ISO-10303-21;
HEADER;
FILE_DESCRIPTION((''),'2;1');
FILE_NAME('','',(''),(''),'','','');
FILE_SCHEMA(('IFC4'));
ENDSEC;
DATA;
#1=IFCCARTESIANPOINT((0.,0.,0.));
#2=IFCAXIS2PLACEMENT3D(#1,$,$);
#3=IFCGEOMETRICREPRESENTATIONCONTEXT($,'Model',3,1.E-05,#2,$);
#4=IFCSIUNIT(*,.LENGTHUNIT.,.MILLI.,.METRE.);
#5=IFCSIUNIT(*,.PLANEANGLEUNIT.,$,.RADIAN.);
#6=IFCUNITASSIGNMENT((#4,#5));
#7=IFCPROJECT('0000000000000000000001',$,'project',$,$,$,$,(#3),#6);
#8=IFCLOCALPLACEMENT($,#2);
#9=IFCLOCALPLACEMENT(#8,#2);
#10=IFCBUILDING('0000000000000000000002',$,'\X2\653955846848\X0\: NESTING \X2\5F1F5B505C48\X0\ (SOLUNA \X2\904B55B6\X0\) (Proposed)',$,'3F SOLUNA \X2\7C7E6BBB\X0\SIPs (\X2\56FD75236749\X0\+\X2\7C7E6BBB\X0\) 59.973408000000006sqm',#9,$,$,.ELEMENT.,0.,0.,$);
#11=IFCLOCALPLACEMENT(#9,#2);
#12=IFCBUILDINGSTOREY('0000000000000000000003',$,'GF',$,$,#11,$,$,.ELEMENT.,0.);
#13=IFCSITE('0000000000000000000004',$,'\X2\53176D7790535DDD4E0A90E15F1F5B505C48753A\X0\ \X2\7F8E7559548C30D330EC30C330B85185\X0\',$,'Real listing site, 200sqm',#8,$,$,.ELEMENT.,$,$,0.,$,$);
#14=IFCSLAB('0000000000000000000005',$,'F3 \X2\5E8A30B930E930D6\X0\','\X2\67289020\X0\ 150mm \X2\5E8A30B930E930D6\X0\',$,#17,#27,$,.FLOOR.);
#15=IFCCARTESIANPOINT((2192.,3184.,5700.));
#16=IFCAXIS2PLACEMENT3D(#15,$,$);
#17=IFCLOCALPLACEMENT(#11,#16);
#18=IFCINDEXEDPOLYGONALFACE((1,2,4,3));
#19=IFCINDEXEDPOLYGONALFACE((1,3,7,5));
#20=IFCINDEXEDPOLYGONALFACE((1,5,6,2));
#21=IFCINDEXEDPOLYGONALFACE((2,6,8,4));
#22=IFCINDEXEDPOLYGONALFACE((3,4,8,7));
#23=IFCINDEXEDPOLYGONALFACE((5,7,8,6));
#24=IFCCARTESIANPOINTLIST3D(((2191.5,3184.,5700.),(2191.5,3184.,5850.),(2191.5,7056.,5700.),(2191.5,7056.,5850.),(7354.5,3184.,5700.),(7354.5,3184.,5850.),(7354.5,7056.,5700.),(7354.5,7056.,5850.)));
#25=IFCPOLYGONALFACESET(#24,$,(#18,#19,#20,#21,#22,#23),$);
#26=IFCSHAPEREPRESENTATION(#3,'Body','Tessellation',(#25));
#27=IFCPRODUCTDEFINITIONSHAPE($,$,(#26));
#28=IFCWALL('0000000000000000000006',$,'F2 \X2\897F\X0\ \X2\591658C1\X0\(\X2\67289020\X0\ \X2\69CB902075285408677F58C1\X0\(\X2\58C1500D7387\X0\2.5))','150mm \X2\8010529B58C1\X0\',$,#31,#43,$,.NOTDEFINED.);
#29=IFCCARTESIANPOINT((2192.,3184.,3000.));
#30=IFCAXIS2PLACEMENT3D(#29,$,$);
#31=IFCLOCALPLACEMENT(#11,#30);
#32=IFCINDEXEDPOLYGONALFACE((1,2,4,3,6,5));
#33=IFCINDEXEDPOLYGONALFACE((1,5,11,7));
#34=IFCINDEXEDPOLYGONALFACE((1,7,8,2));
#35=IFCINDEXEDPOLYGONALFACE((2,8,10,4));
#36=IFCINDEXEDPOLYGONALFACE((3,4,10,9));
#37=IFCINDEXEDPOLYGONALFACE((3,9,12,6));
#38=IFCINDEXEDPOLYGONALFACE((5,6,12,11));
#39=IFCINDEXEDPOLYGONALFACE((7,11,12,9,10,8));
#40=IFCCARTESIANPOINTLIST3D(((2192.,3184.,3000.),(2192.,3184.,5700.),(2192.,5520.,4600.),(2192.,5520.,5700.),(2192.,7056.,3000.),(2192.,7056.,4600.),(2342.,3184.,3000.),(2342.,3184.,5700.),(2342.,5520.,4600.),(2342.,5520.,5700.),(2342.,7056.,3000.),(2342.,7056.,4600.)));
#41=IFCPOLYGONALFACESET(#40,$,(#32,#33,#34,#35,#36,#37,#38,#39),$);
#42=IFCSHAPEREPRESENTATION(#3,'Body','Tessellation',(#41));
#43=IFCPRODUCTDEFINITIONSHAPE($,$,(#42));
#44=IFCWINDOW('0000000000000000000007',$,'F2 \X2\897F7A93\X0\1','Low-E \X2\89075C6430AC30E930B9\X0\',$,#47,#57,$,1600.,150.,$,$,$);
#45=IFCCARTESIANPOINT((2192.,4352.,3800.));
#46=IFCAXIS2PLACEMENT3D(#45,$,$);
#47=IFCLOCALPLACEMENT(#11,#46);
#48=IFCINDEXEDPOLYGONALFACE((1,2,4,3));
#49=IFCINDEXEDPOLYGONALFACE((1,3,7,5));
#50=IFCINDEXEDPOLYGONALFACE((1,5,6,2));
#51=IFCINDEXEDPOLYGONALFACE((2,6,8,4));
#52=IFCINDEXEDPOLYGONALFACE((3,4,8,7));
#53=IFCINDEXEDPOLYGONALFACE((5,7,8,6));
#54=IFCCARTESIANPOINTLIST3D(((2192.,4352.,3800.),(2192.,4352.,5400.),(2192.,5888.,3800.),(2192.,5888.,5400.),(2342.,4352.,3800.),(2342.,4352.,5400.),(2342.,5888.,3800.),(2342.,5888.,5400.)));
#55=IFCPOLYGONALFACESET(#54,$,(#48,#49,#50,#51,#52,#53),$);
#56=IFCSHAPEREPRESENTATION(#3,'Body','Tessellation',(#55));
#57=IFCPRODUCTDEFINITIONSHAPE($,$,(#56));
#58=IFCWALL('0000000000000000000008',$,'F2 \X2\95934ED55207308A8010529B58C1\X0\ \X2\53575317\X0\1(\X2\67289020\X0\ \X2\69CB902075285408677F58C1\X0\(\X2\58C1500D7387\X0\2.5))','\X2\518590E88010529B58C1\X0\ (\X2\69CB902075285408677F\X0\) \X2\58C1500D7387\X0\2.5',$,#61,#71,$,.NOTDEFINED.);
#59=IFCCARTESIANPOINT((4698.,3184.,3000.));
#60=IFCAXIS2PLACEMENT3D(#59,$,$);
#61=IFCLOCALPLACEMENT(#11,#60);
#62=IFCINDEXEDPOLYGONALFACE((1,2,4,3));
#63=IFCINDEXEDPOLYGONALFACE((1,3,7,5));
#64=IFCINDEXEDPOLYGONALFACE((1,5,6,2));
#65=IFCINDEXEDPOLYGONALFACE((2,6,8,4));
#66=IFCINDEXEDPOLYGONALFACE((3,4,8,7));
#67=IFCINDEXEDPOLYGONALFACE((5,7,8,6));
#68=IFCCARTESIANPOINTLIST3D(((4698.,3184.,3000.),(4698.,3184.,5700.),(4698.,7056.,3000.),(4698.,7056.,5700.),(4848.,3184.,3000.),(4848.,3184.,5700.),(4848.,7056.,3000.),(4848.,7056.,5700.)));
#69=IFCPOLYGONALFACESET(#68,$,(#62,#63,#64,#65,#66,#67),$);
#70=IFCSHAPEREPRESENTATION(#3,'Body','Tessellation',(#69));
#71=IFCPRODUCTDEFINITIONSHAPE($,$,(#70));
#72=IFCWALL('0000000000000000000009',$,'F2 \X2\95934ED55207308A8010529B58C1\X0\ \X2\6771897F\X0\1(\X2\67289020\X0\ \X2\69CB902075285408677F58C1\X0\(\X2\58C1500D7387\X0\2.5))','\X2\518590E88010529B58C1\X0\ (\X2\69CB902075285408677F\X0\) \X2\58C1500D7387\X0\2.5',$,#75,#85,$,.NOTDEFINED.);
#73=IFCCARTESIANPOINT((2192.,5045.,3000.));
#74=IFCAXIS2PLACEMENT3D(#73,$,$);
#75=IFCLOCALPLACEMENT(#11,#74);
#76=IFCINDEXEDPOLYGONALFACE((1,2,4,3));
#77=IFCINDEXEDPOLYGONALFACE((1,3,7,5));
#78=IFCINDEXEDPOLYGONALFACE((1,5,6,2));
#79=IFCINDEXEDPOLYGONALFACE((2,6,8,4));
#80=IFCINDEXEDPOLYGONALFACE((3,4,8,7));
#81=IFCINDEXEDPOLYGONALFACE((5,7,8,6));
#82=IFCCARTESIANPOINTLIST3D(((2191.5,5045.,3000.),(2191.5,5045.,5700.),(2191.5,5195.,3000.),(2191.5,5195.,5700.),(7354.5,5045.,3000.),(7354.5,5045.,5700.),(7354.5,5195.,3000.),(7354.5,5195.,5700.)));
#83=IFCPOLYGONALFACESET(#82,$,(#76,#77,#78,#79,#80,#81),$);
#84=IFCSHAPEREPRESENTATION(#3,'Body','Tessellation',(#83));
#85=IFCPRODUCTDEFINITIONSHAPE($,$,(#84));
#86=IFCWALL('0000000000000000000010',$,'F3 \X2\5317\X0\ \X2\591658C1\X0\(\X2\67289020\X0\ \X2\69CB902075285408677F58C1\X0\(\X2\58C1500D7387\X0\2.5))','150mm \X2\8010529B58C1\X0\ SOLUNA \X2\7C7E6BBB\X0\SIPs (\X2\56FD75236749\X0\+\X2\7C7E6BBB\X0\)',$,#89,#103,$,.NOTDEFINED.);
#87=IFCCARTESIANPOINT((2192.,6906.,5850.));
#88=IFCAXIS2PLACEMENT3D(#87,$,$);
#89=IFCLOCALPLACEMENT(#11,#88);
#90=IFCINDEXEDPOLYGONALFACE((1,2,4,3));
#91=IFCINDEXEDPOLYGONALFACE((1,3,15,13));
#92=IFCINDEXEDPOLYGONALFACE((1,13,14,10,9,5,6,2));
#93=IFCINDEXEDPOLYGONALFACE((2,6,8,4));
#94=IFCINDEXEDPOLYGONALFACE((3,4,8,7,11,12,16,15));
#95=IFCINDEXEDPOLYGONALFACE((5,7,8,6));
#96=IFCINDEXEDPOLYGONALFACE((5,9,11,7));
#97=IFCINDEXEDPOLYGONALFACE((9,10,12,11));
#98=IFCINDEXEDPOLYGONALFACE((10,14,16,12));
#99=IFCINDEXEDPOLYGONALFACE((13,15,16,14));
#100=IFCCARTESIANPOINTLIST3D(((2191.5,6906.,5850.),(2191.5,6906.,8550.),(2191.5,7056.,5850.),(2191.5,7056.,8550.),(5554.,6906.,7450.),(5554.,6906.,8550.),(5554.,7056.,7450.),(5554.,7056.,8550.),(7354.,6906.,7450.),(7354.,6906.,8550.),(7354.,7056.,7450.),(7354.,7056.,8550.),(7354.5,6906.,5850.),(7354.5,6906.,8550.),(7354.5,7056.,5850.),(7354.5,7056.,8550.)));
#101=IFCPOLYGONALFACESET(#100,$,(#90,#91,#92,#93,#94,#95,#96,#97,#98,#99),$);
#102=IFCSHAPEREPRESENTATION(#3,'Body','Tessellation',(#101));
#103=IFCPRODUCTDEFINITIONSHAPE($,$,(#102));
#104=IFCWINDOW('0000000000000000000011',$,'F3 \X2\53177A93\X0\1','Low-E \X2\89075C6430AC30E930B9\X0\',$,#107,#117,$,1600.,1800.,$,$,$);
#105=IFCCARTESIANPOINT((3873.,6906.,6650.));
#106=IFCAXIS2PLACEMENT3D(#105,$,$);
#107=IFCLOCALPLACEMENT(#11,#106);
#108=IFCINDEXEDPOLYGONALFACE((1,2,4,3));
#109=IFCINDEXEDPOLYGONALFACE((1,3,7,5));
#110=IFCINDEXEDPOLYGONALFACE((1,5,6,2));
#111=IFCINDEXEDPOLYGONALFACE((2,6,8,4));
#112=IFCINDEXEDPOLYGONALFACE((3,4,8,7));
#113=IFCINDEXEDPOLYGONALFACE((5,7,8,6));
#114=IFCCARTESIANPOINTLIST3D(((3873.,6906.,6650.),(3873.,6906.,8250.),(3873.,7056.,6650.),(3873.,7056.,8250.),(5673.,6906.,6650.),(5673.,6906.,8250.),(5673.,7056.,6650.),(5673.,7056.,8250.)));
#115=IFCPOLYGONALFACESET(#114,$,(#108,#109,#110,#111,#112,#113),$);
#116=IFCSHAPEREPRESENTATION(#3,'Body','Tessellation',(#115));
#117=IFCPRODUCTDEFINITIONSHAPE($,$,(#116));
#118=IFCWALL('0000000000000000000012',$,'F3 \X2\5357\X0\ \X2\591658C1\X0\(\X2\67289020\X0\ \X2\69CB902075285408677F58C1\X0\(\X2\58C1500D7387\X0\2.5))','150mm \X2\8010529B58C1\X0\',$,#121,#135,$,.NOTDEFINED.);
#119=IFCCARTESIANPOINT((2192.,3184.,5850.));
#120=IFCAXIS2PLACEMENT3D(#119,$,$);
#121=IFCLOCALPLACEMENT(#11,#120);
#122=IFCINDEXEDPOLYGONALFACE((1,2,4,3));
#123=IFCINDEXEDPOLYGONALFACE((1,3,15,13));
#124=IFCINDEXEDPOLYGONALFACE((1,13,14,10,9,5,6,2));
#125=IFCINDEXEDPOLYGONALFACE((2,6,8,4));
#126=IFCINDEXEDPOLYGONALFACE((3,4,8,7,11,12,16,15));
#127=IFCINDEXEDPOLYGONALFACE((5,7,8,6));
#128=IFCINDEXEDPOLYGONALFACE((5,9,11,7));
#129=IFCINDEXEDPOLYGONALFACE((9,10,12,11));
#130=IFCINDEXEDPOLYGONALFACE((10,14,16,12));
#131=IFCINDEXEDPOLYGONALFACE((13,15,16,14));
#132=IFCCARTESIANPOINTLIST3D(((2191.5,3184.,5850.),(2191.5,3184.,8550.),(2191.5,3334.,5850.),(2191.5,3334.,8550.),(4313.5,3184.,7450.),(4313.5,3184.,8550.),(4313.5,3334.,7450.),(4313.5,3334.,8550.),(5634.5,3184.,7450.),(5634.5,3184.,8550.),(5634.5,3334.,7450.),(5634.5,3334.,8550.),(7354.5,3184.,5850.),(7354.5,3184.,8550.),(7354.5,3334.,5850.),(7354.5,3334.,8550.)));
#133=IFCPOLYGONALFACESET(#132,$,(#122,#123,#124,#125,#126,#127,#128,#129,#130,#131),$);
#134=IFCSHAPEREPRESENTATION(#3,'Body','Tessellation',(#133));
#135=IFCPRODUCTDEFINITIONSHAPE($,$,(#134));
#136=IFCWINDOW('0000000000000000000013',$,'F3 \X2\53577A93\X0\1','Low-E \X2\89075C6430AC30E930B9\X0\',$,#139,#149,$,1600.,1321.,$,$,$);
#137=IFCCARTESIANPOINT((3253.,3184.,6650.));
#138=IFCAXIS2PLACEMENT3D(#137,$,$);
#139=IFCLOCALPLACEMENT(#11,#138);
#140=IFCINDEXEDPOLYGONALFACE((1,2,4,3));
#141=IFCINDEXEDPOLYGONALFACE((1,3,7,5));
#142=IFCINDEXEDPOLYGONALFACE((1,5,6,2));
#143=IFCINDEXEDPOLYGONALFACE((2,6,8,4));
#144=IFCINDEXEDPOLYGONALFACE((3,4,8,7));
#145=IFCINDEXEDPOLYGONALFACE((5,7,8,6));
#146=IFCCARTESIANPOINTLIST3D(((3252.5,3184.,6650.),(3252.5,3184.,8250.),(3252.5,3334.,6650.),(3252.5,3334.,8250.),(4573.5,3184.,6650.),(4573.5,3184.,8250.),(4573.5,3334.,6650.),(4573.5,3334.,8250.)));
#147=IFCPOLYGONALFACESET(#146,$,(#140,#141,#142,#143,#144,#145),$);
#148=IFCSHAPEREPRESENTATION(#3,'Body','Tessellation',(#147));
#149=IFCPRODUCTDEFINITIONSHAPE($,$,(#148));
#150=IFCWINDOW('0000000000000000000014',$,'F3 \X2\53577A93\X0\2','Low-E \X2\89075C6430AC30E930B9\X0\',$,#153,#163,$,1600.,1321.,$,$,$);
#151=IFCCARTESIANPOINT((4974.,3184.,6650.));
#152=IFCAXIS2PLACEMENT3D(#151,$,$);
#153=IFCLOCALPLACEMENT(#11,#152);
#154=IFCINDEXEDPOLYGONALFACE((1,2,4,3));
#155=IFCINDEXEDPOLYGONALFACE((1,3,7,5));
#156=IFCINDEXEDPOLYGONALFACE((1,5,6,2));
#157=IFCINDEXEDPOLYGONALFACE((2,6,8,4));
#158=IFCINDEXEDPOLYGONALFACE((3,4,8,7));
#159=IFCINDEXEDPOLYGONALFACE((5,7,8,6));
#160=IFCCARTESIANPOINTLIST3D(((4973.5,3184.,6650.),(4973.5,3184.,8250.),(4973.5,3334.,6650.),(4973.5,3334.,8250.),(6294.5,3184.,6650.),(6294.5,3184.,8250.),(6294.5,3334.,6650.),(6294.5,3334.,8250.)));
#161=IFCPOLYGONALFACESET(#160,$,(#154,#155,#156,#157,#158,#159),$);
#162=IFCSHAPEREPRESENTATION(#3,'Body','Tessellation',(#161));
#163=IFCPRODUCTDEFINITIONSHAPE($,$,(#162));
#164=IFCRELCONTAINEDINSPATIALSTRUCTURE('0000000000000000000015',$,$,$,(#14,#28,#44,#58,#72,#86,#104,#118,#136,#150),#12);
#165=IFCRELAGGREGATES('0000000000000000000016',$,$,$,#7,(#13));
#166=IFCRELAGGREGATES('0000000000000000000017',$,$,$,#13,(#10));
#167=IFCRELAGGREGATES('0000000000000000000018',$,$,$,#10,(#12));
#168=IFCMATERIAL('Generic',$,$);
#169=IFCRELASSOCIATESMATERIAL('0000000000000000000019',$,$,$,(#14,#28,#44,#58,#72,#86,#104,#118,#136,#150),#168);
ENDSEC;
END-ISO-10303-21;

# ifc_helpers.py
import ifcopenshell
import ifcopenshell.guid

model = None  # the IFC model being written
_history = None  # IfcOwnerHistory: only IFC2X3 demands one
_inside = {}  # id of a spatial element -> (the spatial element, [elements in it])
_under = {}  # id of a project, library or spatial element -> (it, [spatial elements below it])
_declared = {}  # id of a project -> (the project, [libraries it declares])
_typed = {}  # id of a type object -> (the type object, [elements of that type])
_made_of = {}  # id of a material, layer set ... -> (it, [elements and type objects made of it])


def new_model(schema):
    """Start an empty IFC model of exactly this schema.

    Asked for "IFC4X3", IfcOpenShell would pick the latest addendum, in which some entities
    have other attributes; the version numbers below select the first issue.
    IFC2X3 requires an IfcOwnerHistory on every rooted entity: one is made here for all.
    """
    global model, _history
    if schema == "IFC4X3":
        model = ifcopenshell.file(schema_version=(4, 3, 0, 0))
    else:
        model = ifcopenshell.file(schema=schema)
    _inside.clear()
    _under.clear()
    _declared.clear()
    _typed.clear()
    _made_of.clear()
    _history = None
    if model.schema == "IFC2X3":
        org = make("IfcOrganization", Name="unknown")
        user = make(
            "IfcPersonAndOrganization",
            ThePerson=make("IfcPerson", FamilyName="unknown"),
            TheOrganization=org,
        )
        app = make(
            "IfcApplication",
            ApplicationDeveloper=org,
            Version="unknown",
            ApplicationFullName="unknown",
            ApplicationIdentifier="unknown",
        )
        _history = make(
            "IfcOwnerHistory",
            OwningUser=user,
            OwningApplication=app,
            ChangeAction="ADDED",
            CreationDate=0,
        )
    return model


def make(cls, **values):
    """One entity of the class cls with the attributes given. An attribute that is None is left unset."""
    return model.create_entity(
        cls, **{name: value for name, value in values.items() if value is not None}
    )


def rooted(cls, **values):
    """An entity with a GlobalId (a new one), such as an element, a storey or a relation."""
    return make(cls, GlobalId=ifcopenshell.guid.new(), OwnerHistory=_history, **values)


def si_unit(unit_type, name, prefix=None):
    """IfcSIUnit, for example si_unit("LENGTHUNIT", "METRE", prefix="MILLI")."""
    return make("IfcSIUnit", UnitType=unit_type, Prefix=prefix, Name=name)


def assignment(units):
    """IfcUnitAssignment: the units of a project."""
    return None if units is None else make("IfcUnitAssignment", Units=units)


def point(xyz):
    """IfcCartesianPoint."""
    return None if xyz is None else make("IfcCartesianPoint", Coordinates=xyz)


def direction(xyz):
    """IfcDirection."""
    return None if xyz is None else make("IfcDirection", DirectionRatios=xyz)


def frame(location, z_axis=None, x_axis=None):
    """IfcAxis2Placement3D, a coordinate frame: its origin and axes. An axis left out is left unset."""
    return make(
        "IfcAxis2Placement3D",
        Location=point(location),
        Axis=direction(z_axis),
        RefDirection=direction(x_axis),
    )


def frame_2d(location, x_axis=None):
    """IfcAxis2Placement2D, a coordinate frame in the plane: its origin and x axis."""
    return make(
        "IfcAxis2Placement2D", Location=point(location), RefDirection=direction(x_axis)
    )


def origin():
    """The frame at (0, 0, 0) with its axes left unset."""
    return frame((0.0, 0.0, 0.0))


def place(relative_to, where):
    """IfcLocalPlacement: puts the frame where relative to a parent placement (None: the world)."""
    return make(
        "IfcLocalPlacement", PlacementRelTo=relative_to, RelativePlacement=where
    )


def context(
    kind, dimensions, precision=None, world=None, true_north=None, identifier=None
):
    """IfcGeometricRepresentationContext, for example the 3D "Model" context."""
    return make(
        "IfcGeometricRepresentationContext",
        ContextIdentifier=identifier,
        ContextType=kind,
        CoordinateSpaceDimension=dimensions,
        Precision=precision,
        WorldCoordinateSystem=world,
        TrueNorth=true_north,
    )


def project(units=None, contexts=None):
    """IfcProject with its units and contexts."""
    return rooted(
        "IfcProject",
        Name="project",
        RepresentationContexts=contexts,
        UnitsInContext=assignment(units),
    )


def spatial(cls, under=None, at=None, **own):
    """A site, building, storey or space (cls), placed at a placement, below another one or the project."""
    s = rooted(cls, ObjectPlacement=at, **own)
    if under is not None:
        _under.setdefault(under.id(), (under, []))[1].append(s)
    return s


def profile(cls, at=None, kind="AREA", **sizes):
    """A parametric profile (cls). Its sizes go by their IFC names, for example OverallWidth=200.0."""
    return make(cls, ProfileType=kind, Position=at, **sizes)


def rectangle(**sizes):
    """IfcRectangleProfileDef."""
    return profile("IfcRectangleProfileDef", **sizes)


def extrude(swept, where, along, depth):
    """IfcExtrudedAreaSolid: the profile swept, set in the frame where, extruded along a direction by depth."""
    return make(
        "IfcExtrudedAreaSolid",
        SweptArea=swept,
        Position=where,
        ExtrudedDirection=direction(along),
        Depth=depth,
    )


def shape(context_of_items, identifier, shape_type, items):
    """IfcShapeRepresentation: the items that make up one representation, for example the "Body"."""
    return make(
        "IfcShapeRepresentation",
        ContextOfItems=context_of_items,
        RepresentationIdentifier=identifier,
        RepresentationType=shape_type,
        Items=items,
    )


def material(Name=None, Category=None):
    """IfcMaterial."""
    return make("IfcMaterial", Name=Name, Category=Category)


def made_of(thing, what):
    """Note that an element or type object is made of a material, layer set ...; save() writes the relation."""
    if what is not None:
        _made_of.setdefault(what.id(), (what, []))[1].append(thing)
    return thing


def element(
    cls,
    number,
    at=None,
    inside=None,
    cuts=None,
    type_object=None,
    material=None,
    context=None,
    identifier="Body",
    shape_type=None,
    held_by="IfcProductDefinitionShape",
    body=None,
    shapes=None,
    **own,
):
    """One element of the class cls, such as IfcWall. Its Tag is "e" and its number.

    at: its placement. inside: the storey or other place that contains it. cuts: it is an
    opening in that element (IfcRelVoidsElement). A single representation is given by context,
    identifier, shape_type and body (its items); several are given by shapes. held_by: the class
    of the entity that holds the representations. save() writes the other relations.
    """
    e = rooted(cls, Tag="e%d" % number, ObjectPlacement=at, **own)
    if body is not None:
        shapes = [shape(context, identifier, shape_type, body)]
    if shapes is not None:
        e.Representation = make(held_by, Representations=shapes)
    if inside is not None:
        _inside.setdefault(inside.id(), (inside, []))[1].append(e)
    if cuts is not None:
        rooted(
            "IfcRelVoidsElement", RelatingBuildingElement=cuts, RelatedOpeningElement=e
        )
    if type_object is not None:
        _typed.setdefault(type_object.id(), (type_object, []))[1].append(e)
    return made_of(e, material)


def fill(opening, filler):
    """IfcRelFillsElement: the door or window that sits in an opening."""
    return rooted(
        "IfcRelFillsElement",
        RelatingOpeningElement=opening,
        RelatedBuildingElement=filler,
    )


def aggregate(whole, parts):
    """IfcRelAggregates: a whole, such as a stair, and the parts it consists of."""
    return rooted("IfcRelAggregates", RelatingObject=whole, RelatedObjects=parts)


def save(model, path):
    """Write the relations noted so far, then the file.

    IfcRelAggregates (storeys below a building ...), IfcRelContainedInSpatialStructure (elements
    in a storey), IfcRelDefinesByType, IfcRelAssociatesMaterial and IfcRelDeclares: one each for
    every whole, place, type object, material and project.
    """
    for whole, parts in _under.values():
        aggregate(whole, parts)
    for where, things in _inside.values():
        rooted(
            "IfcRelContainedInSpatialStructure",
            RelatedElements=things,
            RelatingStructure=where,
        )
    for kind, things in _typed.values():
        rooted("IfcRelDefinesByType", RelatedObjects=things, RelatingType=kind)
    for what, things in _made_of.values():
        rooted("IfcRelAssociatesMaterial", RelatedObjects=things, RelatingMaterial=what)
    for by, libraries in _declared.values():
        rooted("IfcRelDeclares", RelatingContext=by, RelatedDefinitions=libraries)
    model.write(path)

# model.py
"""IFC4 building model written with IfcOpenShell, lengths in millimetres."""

from ifc_helpers import new_model, si_unit, frame, frame_2d, origin, place, context, project, spatial, rectangle, extrude, material, element, fill, save


model = new_model("IFC4")

# Units and contexts
model_context = context("Model", 3, precision=1e-05, world=origin())
ifc_project = project(units=[si_unit("LENGTHUNIT", "METRE", prefix="MILLI"), si_unit("PLANEANGLEUNIT", "RADIAN")], contexts=[model_context])

# Site, building, storey
site_placement = place(None, origin())
site = spatial("IfcSite", under=ifc_project, at=site_placement, Name="北海道川上郡弟子屈町 美留和ビレッジ内", ObjectType="Real listing site, 200sqm", CompositionType="ELEMENT", RefElevation=0.0)
building_placement = place(site_placement, origin())
building = spatial("IfcBuilding", under=site, at=building_placement, Name="改善案: NESTING 弟子屈 (SOLUNA 運営) (Proposed)", ObjectType="3F SOLUNA 籾殻SIPs (国産杉+籾殻) 59.973408000000006sqm", CompositionType="ELEMENT", ElevationOfRefHeight=0.0, ElevationOfTerrain=0.0)
storey_placement = place(building_placement, origin())
storey = spatial("IfcBuildingStorey", under=building, at=storey_placement, Name="GF", CompositionType="ELEMENT", Elevation=0.0)

# Slab
ifc_material_1 = material(Name="Generic")
slab_placement = place(storey_placement, frame((2192.0, 3184.0, 5700.0)))
element("IfcSlab", 1, at=slab_placement, inside=storey, material=ifc_material_1, Name="F3 床スラブ", Description="木造 150mm 床スラブ", PredefinedType="FLOOR", context=model_context, shape_type="SweptSolid", body=[
    extrude(rectangle(XDim=5163.0, YDim=3872.0, at=frame_2d((2581.0, 1936.0))), frame((2192.0, 3184.0, 5700.0)), (0.0, 0.0, 1.0), 150.0),
])

# Wall, opening, window
wall_1_placement = place(storey_placement, frame((2192.0, 3184.0, 3000.0)))
wall_1 = element("IfcWall", 2, at=wall_1_placement, inside=storey, material=ifc_material_1, Name="F2 西 外壁(木造 構造用合板壁(壁倍率2.5))", Description="150mm 耐力壁", PredefinedType="NOTDEFINED", context=model_context, shape_type="SweptSolid", body=[
    extrude(rectangle(XDim=150.0, YDim=3872.0, at=frame_2d((75.0, 1936.0))), frame((2192.0, 3184.0, 3000.0)), (0.0, 0.0, 1.0), 2700.0),
])
opening_1_placement = place(storey_placement, frame((2192.0, 4352.0, 3800.0)))
opening_1 = element("IfcOpeningElement", 3, at=opening_1_placement, cuts=wall_1, PredefinedType="NOTDEFINED", context=model_context, shape_type="SweptSolid", body=[
    extrude(rectangle(XDim=150.0, YDim=1536.0, at=frame_2d((75.0, 768.0))), frame((2192.0, 4352.0, 3800.0)), (0.0, 0.0, 1.0), 1600.0),
])
window_1_placement = place(storey_placement, frame((2192.0, 4352.0, 3800.0)))
window_1 = element("IfcWindow", 4, at=window_1_placement, inside=storey, material=ifc_material_1, Name="F2 西窓1", Description="Low-E 複層ガラス", OverallHeight=1600.0, OverallWidth=150.0, context=model_context, shape_type="SweptSolid", body=[
    extrude(rectangle(XDim=150.0, YDim=1536.0, at=frame_2d((75.0, 768.0))), frame((2192.0, 4352.0, 3800.0)), (0.0, 0.0, 1.0), 1600.0),
])
fill(opening_1, window_1)

# Walls
wall_2_placement = place(storey_placement, frame((4698.0, 3184.0, 3000.0)))
element("IfcWall", 5, at=wall_2_placement, inside=storey, material=ifc_material_1, Name="F2 間仕切り耐力壁 南北1(木造 構造用合板壁(壁倍率2.5))", Description="内部耐力壁 (構造用合板) 壁倍率2.5", PredefinedType="NOTDEFINED", context=model_context, shape_type="SweptSolid", body=[
    extrude(rectangle(XDim=150.0, YDim=3872.0, at=frame_2d((75.0, 1936.0))), frame((4698.0, 3184.0, 3000.0)), (0.0, 0.0, 1.0), 2700.0),
])
wall_3_placement = place(storey_placement, frame((2192.0, 5045.0, 3000.0)))
element("IfcWall", 6, at=wall_3_placement, inside=storey, material=ifc_material_1, Name="F2 間仕切り耐力壁 東西1(木造 構造用合板壁(壁倍率2.5))", Description="内部耐力壁 (構造用合板) 壁倍率2.5", PredefinedType="NOTDEFINED", context=model_context, shape_type="SweptSolid", body=[
    extrude(rectangle(XDim=5163.0, YDim=150.0, at=frame_2d((2581.0, 75.0))), frame((2192.0, 5045.0, 3000.0)), (0.0, 0.0, 1.0), 2700.0),
])

# Wall, opening, window
wall_4_placement = place(storey_placement, frame((2192.0, 6906.0, 5850.0)))
wall_4 = element("IfcWall", 7, at=wall_4_placement, inside=storey, material=ifc_material_1, Name="F3 北 外壁(木造 構造用合板壁(壁倍率2.5))", Description="150mm 耐力壁 SOLUNA 籾殻SIPs (国産杉+籾殻)", PredefinedType="NOTDEFINED", context=model_context, shape_type="SweptSolid", body=[
    extrude(rectangle(XDim=5163.0, YDim=150.0, at=frame_2d((2581.0, 75.0))), frame((2192.0, 6906.0, 5850.0)), (0.0, 0.0, 1.0), 2700.0),
])
opening_2_placement = place(storey_placement, frame((3873.0, 6906.0, 6650.0)))
opening_2 = element("IfcOpeningElement", 8, at=opening_2_placement, cuts=wall_4, PredefinedType="NOTDEFINED", context=model_context, shape_type="SweptSolid", body=[
    extrude(rectangle(XDim=1800.0, YDim=150.0, at=frame_2d((900.0, 75.0))), frame((3873.0, 6906.0, 6650.0)), (0.0, 0.0, 1.0), 1600.0),
])
window_2_placement = place(storey_placement, frame((3873.0, 6906.0, 6650.0)))
window_2 = element("IfcWindow", 9, at=window_2_placement, inside=storey, material=ifc_material_1, Name="F3 北窓1", Description="Low-E 複層ガラス", OverallHeight=1600.0, OverallWidth=1800.0, context=model_context, shape_type="SweptSolid", body=[
    extrude(rectangle(XDim=1800.0, YDim=150.0, at=frame_2d((900.0, 75.0))), frame((3873.0, 6906.0, 6650.0)), (0.0, 0.0, 1.0), 1600.0),
])
fill(opening_2, window_2)

# Wall, openings, windows
wall_5_placement = place(storey_placement, frame((2192.0, 3184.0, 5850.0)))
wall_5 = element("IfcWall", 10, at=wall_5_placement, inside=storey, material=ifc_material_1, Name="F3 南 外壁(木造 構造用合板壁(壁倍率2.5))", Description="150mm 耐力壁", PredefinedType="NOTDEFINED", context=model_context, shape_type="SweptSolid", body=[
    extrude(rectangle(XDim=5163.0, YDim=150.0, at=frame_2d((2581.0, 75.0))), frame((2192.0, 3184.0, 5850.0)), (0.0, 0.0, 1.0), 2700.0),
])
opening_3_placement = place(storey_placement, frame((3253.0, 3184.0, 6650.0)))
opening_3 = element("IfcOpeningElement", 11, at=opening_3_placement, cuts=wall_5, PredefinedType="NOTDEFINED", context=model_context, shape_type="SweptSolid", body=[
    extrude(rectangle(XDim=1321.0, YDim=150.0, at=frame_2d((660.0, 75.0))), frame((3253.0, 3184.0, 6650.0)), (0.0, 0.0, 1.0), 1600.0),
])
opening_4_placement = place(storey_placement, frame((4974.0, 3184.0, 6650.0)))
opening_4 = element("IfcOpeningElement", 12, at=opening_4_placement, cuts=wall_5, PredefinedType="NOTDEFINED", context=model_context, shape_type="SweptSolid", body=[
    extrude(rectangle(XDim=1321.0, YDim=150.0, at=frame_2d((660.0, 75.0))), frame((4974.0, 3184.0, 6650.0)), (0.0, 0.0, 1.0), 1600.0),
])
window_3_placement = place(storey_placement, frame((3253.0, 3184.0, 6650.0)))
window_3 = element("IfcWindow", 13, at=window_3_placement, inside=storey, material=ifc_material_1, Name="F3 南窓1", Description="Low-E 複層ガラス", OverallHeight=1600.0, OverallWidth=1321.0, context=model_context, shape_type="SweptSolid", body=[
    extrude(rectangle(XDim=1321.0, YDim=150.0, at=frame_2d((660.0, 75.0))), frame((3253.0, 3184.0, 6650.0)), (0.0, 0.0, 1.0), 1600.0),
])
fill(opening_3, window_3)
window_4_placement = place(storey_placement, frame((4974.0, 3184.0, 6650.0)))
window_4 = element("IfcWindow", 14, at=window_4_placement, inside=storey, material=ifc_material_1, Name="F3 南窓2", Description="Low-E 複層ガラス", OverallHeight=1600.0, OverallWidth=1321.0, context=model_context, shape_type="SweptSolid", body=[
    extrude(rectangle(XDim=1321.0, YDim=150.0, at=frame_2d((660.0, 75.0))), frame((4974.0, 3184.0, 6650.0)), (0.0, 0.0, 1.0), 1600.0),
])
fill(opening_4, window_4)

save(model, "model.ifc")
